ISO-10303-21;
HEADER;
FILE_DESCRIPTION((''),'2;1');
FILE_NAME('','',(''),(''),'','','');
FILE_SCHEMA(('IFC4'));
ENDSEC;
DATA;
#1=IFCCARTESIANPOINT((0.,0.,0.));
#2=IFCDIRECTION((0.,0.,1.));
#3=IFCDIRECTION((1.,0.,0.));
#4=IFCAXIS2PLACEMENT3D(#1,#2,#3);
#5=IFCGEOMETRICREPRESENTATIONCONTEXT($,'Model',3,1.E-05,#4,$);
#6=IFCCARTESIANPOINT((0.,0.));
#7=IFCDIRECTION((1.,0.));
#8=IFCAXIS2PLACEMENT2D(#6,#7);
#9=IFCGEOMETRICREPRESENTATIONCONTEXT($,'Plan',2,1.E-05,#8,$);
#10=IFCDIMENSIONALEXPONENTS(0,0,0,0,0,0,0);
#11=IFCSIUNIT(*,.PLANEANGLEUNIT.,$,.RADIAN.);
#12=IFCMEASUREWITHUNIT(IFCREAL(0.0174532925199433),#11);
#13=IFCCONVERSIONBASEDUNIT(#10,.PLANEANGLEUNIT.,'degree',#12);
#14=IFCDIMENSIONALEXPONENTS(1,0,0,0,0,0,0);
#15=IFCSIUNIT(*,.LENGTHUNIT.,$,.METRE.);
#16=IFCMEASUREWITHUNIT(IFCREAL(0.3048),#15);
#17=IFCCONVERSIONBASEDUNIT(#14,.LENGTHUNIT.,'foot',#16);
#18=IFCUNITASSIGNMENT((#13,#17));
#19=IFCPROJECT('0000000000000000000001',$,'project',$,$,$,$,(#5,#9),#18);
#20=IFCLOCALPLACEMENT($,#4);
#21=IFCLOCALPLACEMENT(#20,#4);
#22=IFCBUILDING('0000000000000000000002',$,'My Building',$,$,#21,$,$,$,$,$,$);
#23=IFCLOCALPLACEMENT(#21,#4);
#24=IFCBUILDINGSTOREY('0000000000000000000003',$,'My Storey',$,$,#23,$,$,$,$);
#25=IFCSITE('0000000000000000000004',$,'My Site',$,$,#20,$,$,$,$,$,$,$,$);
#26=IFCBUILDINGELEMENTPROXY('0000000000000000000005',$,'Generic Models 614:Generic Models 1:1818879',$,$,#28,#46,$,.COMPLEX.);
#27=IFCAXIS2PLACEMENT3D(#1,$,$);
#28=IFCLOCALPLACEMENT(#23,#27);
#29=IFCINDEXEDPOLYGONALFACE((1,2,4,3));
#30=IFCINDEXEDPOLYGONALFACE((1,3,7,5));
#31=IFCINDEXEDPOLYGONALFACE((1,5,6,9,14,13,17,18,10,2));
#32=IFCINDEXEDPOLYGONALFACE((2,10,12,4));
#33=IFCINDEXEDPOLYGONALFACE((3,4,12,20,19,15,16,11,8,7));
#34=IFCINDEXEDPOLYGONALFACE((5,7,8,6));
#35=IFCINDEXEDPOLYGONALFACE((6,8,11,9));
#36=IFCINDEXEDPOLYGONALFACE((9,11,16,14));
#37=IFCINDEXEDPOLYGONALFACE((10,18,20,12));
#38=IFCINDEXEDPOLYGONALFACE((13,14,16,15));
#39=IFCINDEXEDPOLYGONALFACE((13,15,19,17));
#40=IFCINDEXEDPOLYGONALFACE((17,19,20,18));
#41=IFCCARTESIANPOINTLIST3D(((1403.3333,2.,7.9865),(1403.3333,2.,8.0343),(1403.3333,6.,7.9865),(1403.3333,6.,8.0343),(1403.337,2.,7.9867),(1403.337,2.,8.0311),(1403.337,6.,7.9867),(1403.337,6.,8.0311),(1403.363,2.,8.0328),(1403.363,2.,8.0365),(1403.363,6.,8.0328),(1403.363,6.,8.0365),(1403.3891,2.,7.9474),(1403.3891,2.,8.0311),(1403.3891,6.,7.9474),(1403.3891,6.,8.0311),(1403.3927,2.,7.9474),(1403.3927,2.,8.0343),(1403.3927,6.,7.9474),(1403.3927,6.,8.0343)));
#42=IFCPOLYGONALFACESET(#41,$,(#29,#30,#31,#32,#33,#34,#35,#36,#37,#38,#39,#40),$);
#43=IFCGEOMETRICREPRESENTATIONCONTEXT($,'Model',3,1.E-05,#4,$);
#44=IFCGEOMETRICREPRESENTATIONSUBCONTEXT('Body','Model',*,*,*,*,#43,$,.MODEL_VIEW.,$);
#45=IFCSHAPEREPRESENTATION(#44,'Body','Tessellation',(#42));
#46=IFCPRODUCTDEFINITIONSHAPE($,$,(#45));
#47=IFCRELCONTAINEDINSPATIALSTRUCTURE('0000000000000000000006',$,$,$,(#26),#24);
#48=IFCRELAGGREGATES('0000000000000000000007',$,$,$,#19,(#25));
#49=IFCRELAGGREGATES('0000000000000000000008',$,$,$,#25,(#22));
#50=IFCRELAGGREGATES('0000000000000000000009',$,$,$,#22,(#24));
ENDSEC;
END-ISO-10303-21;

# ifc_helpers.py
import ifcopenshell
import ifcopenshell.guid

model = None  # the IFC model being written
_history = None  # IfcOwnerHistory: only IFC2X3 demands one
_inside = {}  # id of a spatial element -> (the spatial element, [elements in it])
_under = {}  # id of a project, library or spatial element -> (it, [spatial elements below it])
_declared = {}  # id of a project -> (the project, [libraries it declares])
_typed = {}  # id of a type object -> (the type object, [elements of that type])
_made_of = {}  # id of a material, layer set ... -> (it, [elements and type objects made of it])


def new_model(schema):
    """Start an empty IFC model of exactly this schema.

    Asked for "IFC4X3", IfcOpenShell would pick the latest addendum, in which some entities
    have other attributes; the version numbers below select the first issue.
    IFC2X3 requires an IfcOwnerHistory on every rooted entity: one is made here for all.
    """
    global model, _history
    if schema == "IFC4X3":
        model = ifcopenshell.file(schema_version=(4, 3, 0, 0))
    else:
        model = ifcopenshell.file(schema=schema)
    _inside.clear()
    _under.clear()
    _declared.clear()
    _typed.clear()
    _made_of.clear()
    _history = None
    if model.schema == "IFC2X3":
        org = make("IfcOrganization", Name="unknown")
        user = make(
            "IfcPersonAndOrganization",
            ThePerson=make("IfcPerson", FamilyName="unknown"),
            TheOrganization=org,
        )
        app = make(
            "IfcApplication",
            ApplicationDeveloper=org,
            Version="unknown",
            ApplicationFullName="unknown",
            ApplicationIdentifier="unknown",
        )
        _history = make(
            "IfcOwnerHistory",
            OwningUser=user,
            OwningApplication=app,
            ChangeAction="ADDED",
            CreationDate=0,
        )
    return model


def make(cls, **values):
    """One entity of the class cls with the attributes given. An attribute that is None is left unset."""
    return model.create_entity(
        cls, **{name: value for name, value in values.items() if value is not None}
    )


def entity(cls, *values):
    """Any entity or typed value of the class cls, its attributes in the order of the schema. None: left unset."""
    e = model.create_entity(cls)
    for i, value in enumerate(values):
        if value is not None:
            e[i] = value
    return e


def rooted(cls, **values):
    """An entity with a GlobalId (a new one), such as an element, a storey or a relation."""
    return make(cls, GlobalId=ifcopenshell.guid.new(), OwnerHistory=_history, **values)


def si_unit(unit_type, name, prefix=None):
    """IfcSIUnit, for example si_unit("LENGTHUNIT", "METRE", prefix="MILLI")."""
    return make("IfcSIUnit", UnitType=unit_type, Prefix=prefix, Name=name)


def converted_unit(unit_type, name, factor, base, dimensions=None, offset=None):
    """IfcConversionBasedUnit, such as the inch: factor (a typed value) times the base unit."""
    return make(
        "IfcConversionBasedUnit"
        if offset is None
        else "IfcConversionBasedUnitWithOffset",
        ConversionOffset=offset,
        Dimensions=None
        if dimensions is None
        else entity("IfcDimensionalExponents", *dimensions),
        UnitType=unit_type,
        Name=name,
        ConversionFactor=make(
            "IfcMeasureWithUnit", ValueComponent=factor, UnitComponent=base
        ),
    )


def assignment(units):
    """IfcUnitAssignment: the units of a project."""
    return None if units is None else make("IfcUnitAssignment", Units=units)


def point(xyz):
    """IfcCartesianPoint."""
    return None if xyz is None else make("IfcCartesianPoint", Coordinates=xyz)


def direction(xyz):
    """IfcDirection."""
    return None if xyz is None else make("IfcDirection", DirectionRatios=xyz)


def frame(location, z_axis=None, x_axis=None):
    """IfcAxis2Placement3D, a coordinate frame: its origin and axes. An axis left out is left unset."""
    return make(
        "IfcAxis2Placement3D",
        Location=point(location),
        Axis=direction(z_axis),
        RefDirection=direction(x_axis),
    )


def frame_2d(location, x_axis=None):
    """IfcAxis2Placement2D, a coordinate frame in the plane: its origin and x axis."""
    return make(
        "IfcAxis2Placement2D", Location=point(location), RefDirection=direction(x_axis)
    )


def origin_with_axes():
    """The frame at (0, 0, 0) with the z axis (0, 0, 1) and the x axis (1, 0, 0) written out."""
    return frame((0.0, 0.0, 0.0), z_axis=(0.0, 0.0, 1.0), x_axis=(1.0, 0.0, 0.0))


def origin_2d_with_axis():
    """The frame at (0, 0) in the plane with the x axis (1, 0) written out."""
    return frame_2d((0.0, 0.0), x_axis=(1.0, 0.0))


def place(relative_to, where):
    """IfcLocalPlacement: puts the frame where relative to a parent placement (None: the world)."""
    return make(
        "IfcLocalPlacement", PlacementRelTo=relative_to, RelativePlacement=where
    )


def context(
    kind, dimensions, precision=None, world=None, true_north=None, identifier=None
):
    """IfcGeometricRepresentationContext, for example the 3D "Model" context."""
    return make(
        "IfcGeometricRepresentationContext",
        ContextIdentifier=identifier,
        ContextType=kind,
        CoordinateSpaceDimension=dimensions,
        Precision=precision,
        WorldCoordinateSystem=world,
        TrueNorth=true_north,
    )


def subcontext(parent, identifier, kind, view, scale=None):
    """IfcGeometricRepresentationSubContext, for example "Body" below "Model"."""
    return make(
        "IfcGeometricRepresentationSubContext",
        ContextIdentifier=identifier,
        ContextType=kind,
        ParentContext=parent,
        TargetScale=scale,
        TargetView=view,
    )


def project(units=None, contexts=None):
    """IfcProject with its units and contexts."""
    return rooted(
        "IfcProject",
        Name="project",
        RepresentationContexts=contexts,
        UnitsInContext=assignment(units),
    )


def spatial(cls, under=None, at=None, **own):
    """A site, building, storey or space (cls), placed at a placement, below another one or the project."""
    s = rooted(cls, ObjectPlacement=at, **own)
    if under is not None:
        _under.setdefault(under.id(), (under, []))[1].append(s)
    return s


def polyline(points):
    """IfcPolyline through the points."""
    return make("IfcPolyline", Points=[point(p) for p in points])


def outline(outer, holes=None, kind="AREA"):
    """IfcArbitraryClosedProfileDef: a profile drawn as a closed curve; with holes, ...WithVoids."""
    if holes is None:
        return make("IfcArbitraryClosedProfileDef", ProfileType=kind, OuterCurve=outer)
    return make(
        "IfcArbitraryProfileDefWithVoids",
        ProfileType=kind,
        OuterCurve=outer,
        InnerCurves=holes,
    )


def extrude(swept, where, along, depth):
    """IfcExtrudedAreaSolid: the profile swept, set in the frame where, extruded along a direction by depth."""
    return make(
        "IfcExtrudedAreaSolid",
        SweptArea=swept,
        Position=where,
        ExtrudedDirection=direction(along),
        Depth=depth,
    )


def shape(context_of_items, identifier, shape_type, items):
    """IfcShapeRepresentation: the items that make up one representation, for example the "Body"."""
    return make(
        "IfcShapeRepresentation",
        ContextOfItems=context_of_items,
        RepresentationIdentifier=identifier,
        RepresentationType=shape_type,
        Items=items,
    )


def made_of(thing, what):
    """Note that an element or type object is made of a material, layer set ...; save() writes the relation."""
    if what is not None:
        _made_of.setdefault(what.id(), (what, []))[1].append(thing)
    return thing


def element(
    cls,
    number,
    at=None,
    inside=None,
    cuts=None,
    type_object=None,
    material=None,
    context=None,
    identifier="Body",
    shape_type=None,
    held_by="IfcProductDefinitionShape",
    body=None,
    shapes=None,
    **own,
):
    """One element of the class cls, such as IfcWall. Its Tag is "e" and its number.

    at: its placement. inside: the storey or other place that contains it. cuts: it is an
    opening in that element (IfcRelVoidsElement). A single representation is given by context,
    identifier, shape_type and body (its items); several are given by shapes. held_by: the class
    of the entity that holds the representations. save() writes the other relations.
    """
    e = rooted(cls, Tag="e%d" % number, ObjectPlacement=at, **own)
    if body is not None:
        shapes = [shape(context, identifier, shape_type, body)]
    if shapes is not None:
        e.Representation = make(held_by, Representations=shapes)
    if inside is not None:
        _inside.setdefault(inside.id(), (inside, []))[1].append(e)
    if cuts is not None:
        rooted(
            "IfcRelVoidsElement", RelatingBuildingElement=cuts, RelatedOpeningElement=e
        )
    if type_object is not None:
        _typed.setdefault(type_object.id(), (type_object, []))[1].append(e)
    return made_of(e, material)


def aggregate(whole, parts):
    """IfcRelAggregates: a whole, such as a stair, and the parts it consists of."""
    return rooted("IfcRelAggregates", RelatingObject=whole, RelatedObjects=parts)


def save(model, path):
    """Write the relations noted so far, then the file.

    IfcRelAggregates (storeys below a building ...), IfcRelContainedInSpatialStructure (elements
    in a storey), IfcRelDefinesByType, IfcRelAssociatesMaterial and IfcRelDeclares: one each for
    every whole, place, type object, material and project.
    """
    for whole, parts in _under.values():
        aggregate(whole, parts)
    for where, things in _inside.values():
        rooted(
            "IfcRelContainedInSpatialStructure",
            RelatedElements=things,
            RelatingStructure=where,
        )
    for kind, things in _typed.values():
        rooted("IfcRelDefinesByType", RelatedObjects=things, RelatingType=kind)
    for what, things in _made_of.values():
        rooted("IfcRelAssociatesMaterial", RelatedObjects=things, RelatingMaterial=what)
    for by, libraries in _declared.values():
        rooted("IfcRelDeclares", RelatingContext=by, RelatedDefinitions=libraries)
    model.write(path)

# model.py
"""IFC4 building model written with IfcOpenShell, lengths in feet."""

from ifc_helpers import new_model, entity, si_unit, converted_unit, frame, origin_with_axes, origin_2d_with_axis, place, context, subcontext, project, spatial, polyline, outline, extrude, element, save


model = new_model("IFC4")

# Units and contexts
model_context_1 = context("Model", 3, precision=1e-05, world=origin_with_axes())
plan_context = context("Plan", 2, precision=1e-05, world=origin_2d_with_axis())
model_context_2 = context("Model", 3, precision=1e-05, world=origin_with_axes())
body_context = subcontext(model_context_2, "Body", "Model", "MODEL_VIEW")
ifc_project = project(units=[converted_unit("PLANEANGLEUNIT", "degree", entity("IfcReal", 0.0174532925199433), si_unit("PLANEANGLEUNIT", "RADIAN"), dimensions=[0, 0, 0, 0, 0, 0, 0]), converted_unit("LENGTHUNIT", "foot", entity("IfcReal", 0.3048), si_unit("LENGTHUNIT", "METRE"), dimensions=[1, 0, 0, 0, 0, 0, 0])], contexts=[model_context_1, plan_context])

# Site, building, storey
site_placement = place(None, origin_with_axes())
site = spatial("IfcSite", under=ifc_project, at=site_placement, Name="My Site")
building_placement = place(site_placement, origin_with_axes())
building = spatial("IfcBuilding", under=site, at=building_placement, Name="My Building")
storey_placement = place(building_placement, origin_with_axes())
storey = spatial("IfcBuildingStorey", under=building, at=storey_placement, Name="My Storey")

# Building element proxy
proxy_1_placement = place(storey_placement, frame((1403.3333, 6.0, 7.9474), z_axis=(0.0, -1.0, 0.0), x_axis=(0.0, 0.0, 1.0)))
element("IfcBuildingElementProxy", 1, at=proxy_1_placement, inside=storey, Name="Generic Models 614:Generic Models 1:1818879", PredefinedType="COMPLEX", context=body_context, shape_type="SweptSolid", body=[
    extrude(outline(polyline([(-0.0203, -0.0297), (0.0275, -0.0297), (0.0296, 0.0), (0.0275, 0.0297), (-0.0594, 0.0297), (-0.0594, 0.026), (0.0243, 0.026), (0.026, 0.0), (0.0243, -0.026), (-0.0201, -0.026), (-0.0203, -0.0297)])), frame((0.0594, -0.0297, 0.0), z_axis=(0.0, 0.0, -1.0), x_axis=(1.0, 0.0, 0.0)), (0.0, 0.0, -1.0), 4.0),
])

save(model, "model.ifc")
